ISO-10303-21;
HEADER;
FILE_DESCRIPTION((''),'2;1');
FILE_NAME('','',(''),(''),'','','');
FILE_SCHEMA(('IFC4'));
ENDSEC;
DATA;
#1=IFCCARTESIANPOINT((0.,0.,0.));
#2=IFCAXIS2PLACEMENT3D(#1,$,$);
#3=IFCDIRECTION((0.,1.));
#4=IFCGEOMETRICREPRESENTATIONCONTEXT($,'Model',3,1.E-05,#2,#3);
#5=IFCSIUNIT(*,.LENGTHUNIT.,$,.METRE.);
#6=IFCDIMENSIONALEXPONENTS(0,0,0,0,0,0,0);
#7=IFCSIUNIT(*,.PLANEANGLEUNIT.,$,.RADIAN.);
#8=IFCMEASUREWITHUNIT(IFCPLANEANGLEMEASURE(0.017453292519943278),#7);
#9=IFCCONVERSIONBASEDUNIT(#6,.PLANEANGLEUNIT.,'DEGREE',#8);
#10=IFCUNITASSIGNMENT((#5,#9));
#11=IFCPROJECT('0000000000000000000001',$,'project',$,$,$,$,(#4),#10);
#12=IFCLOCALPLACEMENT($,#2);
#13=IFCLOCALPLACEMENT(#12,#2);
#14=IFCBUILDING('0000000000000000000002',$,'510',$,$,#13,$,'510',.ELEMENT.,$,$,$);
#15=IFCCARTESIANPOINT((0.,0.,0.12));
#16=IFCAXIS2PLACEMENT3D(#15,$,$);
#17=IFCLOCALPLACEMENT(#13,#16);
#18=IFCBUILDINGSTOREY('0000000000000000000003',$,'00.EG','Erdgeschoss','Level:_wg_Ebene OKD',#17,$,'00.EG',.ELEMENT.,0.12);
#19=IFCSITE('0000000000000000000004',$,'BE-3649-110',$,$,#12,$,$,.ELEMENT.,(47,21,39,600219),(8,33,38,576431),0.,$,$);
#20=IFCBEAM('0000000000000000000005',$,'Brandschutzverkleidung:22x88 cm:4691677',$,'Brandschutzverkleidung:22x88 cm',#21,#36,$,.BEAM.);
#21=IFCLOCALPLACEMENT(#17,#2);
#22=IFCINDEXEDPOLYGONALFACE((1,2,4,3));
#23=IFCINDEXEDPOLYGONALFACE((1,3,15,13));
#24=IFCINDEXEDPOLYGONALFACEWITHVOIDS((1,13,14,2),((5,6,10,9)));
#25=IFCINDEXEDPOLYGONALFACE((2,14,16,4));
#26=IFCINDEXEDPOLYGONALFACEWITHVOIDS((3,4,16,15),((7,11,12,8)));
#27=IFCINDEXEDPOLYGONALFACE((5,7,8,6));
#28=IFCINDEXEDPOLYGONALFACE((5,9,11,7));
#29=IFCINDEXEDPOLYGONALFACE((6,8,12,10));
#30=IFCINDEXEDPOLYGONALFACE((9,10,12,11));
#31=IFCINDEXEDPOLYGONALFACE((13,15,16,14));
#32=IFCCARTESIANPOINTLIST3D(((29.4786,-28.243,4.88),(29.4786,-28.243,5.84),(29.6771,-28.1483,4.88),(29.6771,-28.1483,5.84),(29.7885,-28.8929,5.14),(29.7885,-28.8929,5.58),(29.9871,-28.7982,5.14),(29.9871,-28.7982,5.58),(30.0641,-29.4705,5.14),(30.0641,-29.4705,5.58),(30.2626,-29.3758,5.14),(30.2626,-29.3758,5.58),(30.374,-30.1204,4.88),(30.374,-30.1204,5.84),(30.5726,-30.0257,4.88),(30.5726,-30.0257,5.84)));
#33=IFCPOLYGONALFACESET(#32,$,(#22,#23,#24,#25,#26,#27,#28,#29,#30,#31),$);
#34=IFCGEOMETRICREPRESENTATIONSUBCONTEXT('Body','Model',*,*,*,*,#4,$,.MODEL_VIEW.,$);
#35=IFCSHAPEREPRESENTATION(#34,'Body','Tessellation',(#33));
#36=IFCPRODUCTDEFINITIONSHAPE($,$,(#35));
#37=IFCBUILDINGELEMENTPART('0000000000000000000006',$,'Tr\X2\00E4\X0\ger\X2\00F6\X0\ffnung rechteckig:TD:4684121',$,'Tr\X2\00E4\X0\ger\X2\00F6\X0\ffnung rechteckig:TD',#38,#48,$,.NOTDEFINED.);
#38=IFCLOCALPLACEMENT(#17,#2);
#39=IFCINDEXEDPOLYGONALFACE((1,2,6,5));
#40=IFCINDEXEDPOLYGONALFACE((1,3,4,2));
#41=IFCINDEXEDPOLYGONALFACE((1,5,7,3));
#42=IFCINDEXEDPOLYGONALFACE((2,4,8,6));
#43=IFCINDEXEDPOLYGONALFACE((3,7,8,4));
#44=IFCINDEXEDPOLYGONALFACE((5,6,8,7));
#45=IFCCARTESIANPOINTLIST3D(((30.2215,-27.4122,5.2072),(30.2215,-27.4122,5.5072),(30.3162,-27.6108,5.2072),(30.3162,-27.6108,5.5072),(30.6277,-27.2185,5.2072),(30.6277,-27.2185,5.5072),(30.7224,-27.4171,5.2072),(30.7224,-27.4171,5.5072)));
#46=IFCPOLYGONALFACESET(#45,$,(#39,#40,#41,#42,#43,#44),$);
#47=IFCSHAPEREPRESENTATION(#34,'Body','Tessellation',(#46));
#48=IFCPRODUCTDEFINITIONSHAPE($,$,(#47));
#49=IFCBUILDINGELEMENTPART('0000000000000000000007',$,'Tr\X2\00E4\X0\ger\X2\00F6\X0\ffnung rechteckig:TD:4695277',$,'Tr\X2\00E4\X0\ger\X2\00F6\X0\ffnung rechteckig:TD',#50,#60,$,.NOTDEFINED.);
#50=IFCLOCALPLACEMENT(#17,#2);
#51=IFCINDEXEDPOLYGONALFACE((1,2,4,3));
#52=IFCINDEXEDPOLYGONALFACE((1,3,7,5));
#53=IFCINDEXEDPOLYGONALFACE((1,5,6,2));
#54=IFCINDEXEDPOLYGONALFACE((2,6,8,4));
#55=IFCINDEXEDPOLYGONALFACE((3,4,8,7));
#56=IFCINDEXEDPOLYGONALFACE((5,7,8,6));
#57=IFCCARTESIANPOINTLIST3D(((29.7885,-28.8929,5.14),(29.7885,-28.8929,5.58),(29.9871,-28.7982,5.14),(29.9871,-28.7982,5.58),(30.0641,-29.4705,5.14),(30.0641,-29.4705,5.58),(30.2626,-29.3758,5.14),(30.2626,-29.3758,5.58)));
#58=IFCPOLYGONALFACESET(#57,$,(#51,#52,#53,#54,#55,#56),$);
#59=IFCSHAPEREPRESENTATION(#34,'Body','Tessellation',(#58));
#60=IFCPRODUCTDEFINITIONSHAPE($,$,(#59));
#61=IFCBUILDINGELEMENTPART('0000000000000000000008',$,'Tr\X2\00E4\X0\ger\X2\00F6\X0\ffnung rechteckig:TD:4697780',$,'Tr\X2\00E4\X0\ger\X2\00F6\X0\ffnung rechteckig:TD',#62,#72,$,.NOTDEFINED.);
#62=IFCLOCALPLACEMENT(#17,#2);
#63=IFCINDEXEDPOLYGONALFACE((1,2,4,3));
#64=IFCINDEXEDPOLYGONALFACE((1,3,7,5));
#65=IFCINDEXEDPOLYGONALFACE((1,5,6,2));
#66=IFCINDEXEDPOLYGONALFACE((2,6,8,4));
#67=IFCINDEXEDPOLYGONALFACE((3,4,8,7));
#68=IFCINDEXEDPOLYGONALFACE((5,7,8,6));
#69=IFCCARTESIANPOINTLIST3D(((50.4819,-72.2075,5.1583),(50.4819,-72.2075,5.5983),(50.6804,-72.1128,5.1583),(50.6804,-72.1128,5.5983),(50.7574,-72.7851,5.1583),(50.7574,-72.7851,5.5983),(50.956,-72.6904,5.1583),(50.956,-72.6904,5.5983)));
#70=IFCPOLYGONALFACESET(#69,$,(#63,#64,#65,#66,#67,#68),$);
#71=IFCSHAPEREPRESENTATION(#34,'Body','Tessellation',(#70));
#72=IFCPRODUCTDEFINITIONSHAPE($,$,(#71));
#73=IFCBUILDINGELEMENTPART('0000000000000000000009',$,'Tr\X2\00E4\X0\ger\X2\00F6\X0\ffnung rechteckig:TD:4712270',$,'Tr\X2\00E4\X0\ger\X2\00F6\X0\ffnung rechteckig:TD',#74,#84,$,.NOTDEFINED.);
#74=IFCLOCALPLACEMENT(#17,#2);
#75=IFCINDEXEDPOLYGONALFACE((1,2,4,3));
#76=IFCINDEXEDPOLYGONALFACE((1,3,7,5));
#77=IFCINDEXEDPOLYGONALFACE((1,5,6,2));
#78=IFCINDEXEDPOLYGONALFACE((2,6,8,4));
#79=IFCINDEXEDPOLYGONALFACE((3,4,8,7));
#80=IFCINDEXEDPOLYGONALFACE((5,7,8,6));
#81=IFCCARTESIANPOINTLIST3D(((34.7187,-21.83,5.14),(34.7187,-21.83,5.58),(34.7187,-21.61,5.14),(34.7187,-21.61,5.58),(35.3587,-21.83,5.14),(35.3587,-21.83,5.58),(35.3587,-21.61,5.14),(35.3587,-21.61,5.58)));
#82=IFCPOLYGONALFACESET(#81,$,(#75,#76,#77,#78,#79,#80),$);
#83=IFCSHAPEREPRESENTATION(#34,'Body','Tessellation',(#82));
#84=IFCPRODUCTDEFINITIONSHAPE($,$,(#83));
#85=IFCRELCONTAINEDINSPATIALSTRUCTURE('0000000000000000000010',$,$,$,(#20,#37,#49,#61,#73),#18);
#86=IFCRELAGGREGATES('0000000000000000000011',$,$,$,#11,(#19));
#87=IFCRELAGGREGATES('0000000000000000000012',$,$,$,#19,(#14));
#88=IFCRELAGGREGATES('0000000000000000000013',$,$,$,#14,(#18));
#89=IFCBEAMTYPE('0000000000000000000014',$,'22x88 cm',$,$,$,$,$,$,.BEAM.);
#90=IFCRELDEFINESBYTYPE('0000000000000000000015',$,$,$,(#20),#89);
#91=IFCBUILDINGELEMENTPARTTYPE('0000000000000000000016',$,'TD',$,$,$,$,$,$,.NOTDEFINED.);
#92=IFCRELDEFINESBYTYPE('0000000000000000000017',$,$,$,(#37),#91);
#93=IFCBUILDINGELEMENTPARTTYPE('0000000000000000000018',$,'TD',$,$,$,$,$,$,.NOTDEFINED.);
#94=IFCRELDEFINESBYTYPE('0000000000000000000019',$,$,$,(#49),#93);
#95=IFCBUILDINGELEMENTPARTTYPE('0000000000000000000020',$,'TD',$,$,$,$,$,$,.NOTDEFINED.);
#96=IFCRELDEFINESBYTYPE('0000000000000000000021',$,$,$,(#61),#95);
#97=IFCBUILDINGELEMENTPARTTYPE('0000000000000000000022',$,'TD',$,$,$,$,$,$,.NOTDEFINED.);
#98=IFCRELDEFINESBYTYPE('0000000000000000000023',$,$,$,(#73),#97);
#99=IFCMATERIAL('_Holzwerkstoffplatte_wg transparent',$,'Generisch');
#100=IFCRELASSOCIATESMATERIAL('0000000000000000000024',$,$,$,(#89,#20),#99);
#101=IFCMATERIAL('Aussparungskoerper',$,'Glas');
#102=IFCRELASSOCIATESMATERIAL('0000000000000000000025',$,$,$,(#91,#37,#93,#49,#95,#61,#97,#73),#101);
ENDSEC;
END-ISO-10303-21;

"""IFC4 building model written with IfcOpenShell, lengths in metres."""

from ifc_helpers import new_model, entity, si_unit, converted_unit, direction, frame, origin, place, context, subcontext, project, spatial, indexed_curve, outline, extrude, source, transform, mapped, material, type_object, type_shapes, element, save


model = new_model("IFC4")

# Units and contexts
model_context = context("Model", 3, precision=1e-05, world=origin(), true_north=direction((0.0, 1.0)))
body_context = subcontext(model_context, "Body", "Model", "MODEL_VIEW")
ifc_project = project(units=[si_unit("LENGTHUNIT", "METRE"), converted_unit("PLANEANGLEUNIT", "DEGREE", entity("IfcPlaneAngleMeasure", 0.017453292519943278), si_unit("PLANEANGLEUNIT", "RADIAN"), dimensions=[0, 0, 0, 0, 0, 0, 0])], contexts=[model_context])

# Site, building, storey
site_placement = place(None, origin())
site = spatial("IfcSite", under=ifc_project, at=site_placement, Name="BE-3649-110", CompositionType="ELEMENT", RefLatitude=(47, 21, 39, 600219), RefLongitude=(8, 33, 38, 576431), RefElevation=0.0)
building_placement = place(site_placement, origin())
building = spatial("IfcBuilding", under=site, at=building_placement, Name="510", LongName="510", CompositionType="ELEMENT")
storey_placement = place(building_placement, frame((0.0, 0.0, 0.12)))
storey = spatial("IfcBuildingStorey", under=building, at=storey_placement, Name="00.EG", Description="Erdgeschoss", ObjectType="Level:_wg_Ebene OKD", LongName="00.EG", CompositionType="ELEMENT", Elevation=0.12)

# Shared definitions
ifc_material_1 = material(Name="_Holzwerkstoffplatte_wg transparent", Category="Generisch")

# Beam
beam_type_1 = type_object("IfcBeamType", Name="22x88 cm", PredefinedType="BEAM", material=ifc_material_1)
shared_shape_1 = source(origin(), body_context, "Body", "SweptSolid", [
    extrude(outline(indexed_curve([(-1.04, -0.48), (1.04, -0.48), (1.04, 0.48), (-1.04, 0.48), (-1.04, -0.48)], self_intersect=False), holes=[indexed_curve([(-0.32, -0.22), (-0.32, 0.22), (0.32, 0.22), (0.32, -0.22), (-0.32, -0.22)], self_intersect=False)]), frame((29.9263, -29.1817, 0.0), z_axis=(0.902585, 0.430511, 0.0), x_axis=(-0.430511, 0.902585, 0.0)), (0.0, 0.0, 1.0), 0.22),
])
type_shapes(beam_type_1, [shared_shape_1])
beam_1_placement = place(storey_placement, frame((0.0, 0.0, 5.36)))
element("IfcBeam", 1, at=beam_1_placement, inside=storey, type_object=beam_type_1, material=ifc_material_1, Name="Brandschutzverkleidung:22x88 cm:4691677", ObjectType="Brandschutzverkleidung:22x88 cm", PredefinedType="BEAM", context=body_context, shape_type="MappedRepresentation", body=[
    mapped(shared_shape_1, transform((0.0, 0.0, 0.0), scale=1.0)),
])

# Building element parts
ifc_material_2 = material(Name="Aussparungskoerper", Category="Glas")
building_element_part_type_1 = type_object("IfcBuildingElementPartType", Name="TD", PredefinedType="NOTDEFINED", material=ifc_material_2)
shared_shape_2 = source(origin(), body_context, "Body", "SweptSolid", [
    extrude(outline(indexed_curve([(-0.225, -0.15), (0.225, -0.15), (0.225, 0.15), (-0.225, 0.15), (-0.225, -0.15)], self_intersect=False)), frame((0.0, 0.0, -0.22), z_axis=(0.0, 0.0, 1.0), x_axis=(-1.0, 0.0, 0.0)), (0.0, 0.0, 1.0), 0.22),
])
type_shapes(building_element_part_type_1, [shared_shape_2])
building_element_part_1_placement = place(storey_placement, frame((30.5193, -27.5139, 5.3572), z_axis=(0.430511, -0.902585, 0.0), x_axis=(-0.902585, -0.430511, 0.0)))
element("IfcBuildingElementPart", 2, at=building_element_part_1_placement, inside=storey, type_object=building_element_part_type_1, material=ifc_material_2, Name="Trägeröffnung rechteckig:TD:4684121", ObjectType="Trägeröffnung rechteckig:TD", PredefinedType="NOTDEFINED", context=body_context, shape_type="MappedRepresentation", body=[
    mapped(shared_shape_2, transform((0.0, 0.0, 0.0), scale=1.0)),
])
building_element_part_type_2 = type_object("IfcBuildingElementPartType", Name="TD", PredefinedType="NOTDEFINED", material=ifc_material_2)
shared_shape_3 = source(origin(), body_context, "Body", "SweptSolid", [
    extrude(outline(indexed_curve([(-0.11, -0.32), (0.11, -0.32), (0.11, 0.32), (-0.11, 0.32), (-0.11, -0.32)], self_intersect=False)), frame((30.0256, -29.1344, -0.44), z_axis=(0.0, 0.0, 1.0), x_axis=(-0.902585, -0.430511, 0.0)), (0.0, 0.0, 1.0), 0.44),
])
type_shapes(building_element_part_type_2, [shared_shape_3])
building_element_part_2_placement = place(storey_placement, frame((0.0, 0.0, 5.58)))
element("IfcBuildingElementPart", 3, at=building_element_part_2_placement, inside=storey, type_object=building_element_part_type_2, material=ifc_material_2, Name="Trägeröffnung rechteckig:TD:4695277", ObjectType="Trägeröffnung rechteckig:TD", PredefinedType="NOTDEFINED", context=body_context, shape_type="MappedRepresentation", body=[
    mapped(shared_shape_3, transform((0.0, 0.0, 0.0), scale=1.0)),
])
building_element_part_type_3 = type_object("IfcBuildingElementPartType", Name="TD", PredefinedType="NOTDEFINED", material=ifc_material_2)
shared_shape_4 = source(origin(), body_context, "Body", "SweptSolid", [
    extrude(outline(indexed_curve([(-0.11, -0.32), (0.11, -0.32), (0.11, 0.32), (-0.11, 0.32), (-0.11, -0.32)], self_intersect=False)), frame((50.7189, -72.449, -0.44), z_axis=(0.0, 0.0, 1.0), x_axis=(0.902586, 0.43051, 0.0)), (0.0, 0.0, 1.0), 0.44),
])
type_shapes(building_element_part_type_3, [shared_shape_4])
building_element_part_3_placement = place(storey_placement, frame((0.0, 0.0, 5.5983)))
element("IfcBuildingElementPart", 4, at=building_element_part_3_placement, inside=storey, type_object=building_element_part_type_3, material=ifc_material_2, Name="Trägeröffnung rechteckig:TD:4697780", ObjectType="Trägeröffnung rechteckig:TD", PredefinedType="NOTDEFINED", context=body_context, shape_type="MappedRepresentation", body=[
    mapped(shared_shape_4, transform((0.0, 0.0, 0.0), scale=1.0)),
])
building_element_part_type_4 = type_object("IfcBuildingElementPartType", Name="TD", PredefinedType="NOTDEFINED", material=ifc_material_2)
shared_shape_5 = source(origin(), body_context, "Body", "SweptSolid", [
    extrude(outline(indexed_curve([(-0.11, -0.32), (0.11, -0.32), (0.11, 0.32), (-0.11, 0.32), (-0.11, -0.32)], self_intersect=False)), frame((35.0387, -21.72, -0.44), z_axis=(0.0, 0.0, 1.0), x_axis=(0.0, 1.0, 0.0)), (0.0, 0.0, 1.0), 0.44),
])
type_shapes(building_element_part_type_4, [shared_shape_5])
building_element_part_4_placement = place(storey_placement, frame((0.0, 0.0, 5.58)))
element("IfcBuildingElementPart", 5, at=building_element_part_4_placement, inside=storey, type_object=building_element_part_type_4, material=ifc_material_2, Name="Trägeröffnung rechteckig:TD:4712270", ObjectType="Trägeröffnung rechteckig:TD", PredefinedType="NOTDEFINED", context=body_context, shape_type="MappedRepresentation", body=[
    mapped(shared_shape_5, transform((0.0, 0.0, 0.0), scale=1.0)),
])

save(model, "model.ifc")
